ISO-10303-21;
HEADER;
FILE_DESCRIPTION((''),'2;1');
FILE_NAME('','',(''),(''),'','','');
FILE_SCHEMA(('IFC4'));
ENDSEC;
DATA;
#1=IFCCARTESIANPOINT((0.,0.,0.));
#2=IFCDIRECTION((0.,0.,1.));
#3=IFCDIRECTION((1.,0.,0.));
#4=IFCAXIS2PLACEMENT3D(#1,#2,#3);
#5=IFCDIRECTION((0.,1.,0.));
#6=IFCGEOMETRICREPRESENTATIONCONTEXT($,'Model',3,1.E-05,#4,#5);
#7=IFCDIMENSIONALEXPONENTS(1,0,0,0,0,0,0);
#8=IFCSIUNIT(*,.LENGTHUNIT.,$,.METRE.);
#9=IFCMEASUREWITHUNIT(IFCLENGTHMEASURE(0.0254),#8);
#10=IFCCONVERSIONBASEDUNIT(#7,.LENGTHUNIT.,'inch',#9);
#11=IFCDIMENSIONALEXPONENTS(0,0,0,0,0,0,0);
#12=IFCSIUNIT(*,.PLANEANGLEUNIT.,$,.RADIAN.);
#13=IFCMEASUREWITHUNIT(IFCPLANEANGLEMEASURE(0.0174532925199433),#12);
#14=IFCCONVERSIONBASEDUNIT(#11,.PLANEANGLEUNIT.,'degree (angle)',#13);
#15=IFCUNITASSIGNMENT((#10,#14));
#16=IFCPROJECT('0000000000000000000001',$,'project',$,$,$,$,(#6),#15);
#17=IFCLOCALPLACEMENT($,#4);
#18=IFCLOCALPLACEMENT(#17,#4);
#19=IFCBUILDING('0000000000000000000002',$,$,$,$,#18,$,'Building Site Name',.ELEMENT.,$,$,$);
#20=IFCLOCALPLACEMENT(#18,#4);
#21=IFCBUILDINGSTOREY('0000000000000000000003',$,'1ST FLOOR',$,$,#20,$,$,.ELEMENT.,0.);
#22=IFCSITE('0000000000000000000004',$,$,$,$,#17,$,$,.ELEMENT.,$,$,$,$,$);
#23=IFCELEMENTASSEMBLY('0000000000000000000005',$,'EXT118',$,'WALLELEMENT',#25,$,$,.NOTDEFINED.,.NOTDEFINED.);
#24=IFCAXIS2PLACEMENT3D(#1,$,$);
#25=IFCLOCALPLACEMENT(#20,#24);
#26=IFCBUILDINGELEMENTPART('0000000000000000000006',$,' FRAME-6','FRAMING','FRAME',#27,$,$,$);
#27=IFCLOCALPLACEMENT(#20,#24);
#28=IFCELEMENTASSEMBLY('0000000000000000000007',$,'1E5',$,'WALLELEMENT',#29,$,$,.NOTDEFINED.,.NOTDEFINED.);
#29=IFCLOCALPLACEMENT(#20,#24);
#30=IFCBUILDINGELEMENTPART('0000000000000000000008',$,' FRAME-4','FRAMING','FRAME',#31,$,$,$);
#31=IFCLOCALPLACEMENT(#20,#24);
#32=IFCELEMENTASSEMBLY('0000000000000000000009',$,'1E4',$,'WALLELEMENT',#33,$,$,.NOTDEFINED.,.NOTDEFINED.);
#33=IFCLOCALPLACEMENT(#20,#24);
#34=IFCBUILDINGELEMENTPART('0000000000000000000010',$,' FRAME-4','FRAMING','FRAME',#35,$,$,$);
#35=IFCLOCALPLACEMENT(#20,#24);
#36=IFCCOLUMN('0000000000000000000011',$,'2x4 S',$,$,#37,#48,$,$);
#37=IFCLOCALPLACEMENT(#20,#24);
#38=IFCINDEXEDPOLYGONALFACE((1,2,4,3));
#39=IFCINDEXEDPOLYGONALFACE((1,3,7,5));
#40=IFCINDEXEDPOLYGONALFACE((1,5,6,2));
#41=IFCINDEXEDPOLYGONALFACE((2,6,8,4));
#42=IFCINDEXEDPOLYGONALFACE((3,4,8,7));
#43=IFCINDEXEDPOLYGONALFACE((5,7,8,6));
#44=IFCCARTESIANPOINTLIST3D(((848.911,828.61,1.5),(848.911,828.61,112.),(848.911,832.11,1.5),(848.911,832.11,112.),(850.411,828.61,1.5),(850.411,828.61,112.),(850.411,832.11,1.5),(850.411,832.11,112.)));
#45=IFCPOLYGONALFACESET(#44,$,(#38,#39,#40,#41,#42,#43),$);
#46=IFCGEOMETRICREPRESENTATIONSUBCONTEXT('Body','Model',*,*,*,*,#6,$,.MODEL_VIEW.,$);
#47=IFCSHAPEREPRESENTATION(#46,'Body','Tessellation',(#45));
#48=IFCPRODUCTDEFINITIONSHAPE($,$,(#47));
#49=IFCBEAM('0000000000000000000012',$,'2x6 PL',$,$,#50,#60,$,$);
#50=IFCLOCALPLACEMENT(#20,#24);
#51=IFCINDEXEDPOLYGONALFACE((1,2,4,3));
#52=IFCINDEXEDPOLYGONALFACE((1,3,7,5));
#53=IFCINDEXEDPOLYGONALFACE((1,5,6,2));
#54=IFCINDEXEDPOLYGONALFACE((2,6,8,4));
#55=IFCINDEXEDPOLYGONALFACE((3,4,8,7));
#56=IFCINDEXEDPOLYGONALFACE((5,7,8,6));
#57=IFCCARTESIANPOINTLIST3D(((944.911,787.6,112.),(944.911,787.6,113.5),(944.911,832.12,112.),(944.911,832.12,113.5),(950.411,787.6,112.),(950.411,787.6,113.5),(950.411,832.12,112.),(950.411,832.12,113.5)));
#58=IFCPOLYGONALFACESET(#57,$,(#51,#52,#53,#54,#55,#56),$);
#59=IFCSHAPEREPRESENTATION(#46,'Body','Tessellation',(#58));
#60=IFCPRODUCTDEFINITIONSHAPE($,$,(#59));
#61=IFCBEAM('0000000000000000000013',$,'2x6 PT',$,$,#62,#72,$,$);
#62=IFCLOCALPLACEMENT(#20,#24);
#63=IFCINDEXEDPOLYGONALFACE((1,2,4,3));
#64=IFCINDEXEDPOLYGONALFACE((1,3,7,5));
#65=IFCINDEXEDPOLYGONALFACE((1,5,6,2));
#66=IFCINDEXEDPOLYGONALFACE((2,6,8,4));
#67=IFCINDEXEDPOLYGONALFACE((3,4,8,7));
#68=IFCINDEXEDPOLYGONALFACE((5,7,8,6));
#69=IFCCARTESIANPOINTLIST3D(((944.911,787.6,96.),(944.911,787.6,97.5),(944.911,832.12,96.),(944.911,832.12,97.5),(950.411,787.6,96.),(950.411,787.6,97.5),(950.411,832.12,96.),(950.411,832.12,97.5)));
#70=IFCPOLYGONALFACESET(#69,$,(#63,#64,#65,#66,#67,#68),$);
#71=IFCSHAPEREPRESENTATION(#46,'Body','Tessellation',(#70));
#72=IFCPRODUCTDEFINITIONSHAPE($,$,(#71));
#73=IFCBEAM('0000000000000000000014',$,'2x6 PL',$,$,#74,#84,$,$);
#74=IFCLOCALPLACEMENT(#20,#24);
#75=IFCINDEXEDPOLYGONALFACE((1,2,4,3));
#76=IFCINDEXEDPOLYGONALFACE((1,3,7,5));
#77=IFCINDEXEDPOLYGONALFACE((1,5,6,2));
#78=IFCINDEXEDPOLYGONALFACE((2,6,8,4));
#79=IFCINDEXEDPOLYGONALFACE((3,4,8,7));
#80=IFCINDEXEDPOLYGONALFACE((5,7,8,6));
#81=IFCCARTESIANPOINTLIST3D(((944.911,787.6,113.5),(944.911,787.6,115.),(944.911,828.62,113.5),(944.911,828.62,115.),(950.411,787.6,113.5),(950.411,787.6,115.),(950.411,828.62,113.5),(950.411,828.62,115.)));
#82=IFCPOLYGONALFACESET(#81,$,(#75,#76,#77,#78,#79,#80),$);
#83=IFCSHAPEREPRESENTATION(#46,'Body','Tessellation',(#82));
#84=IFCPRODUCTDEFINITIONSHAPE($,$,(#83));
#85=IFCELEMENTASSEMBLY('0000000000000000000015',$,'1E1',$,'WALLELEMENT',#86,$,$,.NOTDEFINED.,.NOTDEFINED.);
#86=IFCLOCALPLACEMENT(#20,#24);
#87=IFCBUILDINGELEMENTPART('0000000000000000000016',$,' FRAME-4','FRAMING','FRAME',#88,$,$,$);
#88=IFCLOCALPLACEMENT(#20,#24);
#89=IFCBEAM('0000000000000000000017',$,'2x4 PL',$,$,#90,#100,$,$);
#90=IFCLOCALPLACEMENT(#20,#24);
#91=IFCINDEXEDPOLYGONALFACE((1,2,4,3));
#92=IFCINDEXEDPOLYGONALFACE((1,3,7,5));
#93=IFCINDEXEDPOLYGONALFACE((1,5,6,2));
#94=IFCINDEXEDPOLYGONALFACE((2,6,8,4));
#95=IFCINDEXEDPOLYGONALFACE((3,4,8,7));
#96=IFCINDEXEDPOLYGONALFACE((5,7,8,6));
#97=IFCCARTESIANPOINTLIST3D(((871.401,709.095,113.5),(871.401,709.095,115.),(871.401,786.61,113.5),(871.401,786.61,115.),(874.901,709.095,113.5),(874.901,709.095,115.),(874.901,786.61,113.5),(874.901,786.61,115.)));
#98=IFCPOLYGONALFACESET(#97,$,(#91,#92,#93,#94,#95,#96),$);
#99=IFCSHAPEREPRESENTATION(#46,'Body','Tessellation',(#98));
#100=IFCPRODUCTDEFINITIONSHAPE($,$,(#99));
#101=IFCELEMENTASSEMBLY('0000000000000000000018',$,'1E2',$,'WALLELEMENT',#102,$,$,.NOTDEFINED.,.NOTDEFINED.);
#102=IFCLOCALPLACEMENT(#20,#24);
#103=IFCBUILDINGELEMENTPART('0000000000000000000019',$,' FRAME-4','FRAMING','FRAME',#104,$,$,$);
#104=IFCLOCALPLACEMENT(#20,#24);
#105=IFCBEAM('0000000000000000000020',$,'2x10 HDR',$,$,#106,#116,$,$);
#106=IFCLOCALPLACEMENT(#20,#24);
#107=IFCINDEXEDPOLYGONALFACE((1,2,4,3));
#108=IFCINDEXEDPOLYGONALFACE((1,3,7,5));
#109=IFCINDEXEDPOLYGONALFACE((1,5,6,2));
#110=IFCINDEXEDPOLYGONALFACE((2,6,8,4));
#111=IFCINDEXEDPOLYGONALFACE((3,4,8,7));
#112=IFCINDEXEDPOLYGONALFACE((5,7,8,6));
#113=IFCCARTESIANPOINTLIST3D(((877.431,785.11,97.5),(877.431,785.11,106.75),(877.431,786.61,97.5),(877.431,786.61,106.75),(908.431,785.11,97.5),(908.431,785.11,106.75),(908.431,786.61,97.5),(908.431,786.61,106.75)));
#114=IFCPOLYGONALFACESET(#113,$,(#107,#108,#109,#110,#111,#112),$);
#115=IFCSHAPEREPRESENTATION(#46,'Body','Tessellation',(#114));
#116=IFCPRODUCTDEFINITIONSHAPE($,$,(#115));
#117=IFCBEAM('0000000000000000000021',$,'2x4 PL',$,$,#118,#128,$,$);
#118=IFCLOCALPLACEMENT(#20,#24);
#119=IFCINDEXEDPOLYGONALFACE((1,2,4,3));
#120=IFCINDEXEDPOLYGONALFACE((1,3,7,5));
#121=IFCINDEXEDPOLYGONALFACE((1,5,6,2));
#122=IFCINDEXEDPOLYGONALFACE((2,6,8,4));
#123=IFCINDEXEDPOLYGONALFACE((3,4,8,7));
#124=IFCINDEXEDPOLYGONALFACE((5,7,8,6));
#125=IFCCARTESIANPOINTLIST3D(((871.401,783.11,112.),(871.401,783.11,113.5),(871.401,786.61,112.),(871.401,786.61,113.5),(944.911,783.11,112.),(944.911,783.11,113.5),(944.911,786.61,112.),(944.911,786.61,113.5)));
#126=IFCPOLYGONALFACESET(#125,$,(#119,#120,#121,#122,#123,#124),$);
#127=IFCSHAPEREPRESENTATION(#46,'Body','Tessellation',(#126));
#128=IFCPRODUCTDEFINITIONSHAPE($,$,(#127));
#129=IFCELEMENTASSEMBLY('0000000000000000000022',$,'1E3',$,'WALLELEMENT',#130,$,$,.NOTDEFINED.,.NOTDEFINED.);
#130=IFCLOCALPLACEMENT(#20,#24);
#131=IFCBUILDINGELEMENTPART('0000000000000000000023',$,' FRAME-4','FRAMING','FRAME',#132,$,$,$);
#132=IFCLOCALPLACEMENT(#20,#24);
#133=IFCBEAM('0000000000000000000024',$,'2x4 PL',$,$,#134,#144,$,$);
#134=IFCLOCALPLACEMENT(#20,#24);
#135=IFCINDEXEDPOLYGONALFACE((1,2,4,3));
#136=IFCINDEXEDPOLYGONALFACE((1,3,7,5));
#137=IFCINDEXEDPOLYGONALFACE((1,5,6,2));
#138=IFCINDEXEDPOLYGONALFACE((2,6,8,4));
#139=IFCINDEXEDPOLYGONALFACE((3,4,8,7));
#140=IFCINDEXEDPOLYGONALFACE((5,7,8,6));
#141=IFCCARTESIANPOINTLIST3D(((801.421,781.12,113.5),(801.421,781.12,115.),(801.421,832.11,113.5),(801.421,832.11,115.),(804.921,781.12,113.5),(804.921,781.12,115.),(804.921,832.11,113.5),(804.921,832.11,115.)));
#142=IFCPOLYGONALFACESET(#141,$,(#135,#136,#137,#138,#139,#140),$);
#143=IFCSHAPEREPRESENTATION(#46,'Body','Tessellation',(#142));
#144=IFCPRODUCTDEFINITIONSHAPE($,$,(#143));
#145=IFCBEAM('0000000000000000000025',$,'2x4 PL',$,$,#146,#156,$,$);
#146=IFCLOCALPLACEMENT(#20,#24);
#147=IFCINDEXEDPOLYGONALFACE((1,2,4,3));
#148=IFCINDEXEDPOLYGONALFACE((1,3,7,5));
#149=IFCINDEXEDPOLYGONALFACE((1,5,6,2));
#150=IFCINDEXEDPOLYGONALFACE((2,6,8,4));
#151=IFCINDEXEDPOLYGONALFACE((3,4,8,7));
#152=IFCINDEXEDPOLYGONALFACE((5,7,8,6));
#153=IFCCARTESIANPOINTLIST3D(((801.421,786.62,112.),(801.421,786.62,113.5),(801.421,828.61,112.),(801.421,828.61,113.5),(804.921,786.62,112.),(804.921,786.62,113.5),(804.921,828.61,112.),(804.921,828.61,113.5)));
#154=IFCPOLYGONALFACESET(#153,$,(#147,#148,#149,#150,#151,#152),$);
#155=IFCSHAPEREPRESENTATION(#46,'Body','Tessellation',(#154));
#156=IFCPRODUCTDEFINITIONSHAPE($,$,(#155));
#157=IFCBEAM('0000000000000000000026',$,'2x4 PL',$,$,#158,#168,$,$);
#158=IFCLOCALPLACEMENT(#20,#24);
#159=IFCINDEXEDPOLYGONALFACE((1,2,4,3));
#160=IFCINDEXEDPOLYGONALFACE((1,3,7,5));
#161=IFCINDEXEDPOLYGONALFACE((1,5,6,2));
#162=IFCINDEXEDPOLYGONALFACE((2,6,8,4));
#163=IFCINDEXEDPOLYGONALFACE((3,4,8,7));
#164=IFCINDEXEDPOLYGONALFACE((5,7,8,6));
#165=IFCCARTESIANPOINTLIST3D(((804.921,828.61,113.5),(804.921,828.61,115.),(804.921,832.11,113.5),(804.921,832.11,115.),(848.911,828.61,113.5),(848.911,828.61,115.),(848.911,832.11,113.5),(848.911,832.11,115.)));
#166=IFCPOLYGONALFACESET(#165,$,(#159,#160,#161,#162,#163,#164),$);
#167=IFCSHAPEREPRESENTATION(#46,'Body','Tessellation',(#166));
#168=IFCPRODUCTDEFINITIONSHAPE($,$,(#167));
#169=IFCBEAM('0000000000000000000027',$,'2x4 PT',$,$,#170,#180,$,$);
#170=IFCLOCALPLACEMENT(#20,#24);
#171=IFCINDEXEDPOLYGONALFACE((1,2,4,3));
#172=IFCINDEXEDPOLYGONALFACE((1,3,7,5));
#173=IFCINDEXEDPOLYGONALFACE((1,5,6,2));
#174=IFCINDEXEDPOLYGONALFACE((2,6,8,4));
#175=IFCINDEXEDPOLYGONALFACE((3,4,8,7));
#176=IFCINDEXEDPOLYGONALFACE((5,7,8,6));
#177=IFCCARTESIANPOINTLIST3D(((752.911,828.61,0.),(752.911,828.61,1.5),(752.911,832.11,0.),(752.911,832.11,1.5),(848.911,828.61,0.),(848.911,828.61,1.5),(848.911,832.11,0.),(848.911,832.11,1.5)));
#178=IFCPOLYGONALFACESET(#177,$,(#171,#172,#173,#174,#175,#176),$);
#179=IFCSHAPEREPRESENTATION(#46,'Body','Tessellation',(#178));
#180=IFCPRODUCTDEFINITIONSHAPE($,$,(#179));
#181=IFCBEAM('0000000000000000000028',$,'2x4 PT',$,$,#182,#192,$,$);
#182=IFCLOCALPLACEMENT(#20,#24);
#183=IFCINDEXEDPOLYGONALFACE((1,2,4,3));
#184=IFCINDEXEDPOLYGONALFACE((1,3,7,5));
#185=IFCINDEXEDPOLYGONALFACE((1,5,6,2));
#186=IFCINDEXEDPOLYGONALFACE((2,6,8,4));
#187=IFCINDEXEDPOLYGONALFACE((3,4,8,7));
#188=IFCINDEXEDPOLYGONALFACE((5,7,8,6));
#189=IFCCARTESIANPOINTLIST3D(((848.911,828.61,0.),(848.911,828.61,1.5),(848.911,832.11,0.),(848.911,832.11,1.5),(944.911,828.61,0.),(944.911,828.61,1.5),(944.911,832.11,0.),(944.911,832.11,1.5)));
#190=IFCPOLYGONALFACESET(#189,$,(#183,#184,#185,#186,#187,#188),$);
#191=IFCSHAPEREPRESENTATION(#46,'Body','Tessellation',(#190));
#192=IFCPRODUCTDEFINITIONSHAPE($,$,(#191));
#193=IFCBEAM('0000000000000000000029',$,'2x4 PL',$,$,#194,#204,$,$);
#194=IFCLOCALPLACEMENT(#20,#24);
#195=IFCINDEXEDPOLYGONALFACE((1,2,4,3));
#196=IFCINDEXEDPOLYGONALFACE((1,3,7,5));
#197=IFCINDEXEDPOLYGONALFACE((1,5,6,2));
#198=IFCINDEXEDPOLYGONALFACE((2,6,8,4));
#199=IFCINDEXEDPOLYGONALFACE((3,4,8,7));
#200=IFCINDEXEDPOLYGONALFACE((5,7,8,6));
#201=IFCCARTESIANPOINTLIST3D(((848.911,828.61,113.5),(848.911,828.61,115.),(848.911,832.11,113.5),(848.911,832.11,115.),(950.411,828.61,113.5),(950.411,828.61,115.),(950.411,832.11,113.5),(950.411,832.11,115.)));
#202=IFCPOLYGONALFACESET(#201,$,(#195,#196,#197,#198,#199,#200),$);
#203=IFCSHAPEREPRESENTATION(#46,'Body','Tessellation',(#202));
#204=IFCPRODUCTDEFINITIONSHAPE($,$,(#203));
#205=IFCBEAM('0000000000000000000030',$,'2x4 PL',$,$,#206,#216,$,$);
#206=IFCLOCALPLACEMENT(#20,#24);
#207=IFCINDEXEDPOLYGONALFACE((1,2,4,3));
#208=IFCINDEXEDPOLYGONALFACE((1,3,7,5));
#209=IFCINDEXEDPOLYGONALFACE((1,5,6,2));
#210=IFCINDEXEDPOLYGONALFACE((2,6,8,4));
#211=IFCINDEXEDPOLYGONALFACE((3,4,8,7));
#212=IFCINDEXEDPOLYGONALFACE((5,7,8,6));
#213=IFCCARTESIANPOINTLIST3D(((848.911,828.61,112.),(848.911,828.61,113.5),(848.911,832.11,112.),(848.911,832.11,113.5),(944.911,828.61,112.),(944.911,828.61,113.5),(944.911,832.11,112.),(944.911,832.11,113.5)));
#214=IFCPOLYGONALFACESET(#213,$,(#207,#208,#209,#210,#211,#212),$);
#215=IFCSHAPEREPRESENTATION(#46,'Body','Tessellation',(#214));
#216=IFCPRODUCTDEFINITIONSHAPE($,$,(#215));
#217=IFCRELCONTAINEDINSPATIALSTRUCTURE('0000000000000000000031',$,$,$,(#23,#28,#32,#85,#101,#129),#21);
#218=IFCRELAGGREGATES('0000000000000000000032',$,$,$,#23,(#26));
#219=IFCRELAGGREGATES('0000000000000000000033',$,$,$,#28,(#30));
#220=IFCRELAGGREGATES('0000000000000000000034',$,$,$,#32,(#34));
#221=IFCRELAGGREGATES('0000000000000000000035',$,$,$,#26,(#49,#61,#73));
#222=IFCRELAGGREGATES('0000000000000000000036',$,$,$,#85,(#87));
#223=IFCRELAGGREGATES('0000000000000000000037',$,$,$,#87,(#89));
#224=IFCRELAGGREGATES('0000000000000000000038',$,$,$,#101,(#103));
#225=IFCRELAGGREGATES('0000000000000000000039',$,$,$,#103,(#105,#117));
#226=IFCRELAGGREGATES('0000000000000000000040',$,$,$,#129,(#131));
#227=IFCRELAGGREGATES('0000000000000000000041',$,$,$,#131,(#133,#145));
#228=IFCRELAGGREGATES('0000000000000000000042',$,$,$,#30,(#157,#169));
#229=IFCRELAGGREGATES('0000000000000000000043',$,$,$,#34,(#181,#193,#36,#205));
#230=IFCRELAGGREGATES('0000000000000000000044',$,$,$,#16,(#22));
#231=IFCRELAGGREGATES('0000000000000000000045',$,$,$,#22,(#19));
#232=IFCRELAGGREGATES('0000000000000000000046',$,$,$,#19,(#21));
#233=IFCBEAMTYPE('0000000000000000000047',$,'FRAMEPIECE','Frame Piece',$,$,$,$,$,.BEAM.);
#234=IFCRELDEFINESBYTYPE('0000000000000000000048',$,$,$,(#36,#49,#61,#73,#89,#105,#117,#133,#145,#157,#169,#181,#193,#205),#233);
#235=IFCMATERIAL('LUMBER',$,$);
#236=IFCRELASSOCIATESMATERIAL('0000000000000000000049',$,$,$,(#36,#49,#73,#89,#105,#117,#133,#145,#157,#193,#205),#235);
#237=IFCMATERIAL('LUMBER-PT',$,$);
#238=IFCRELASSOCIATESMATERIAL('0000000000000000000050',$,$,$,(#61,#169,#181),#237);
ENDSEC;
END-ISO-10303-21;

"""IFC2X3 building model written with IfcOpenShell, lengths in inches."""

from ifc_helpers import new_model, entity, si_unit, converted_unit, direction, frame, frame_2d, origin_with_axes, place, context, subcontext, project, spatial, rectangle, extrude, material, type_object, element, aggregate, save


model = new_model("IFC2X3")

# Units and contexts
model_context = context("Model", 3, precision=1e-05, world=origin_with_axes(), true_north=direction((0.0, 1.0, 0.0)))
body_context = subcontext(model_context, "Body", "Model", "MODEL_VIEW")
ifc_project = project(units=[converted_unit("LENGTHUNIT", "inch", entity("IfcLengthMeasure", 0.0254), si_unit("LENGTHUNIT", "METRE"), dimensions=[1, 0, 0, 0, 0, 0, 0]), converted_unit("PLANEANGLEUNIT", "degree (angle)", entity("IfcPlaneAngleMeasure", 0.0174532925199433), si_unit("PLANEANGLEUNIT", "RADIAN"), dimensions=[0, 0, 0, 0, 0, 0, 0])], contexts=[model_context])

# Site, building, storey
site_placement = place(None, origin_with_axes())
site = spatial("IfcSite", under=ifc_project, at=site_placement, CompositionType="ELEMENT")
building_placement = place(site_placement, origin_with_axes())
building = spatial("IfcBuilding", under=site, at=building_placement, LongName="Building Site Name", CompositionType="ELEMENT")
storey_placement = place(building_placement, origin_with_axes())
storey = spatial("IfcBuildingStorey", under=building, at=storey_placement, Name="1ST FLOOR", CompositionType="ELEMENT", Elevation=0.0)

# Element assemblies, building element parts, column
assembly_1_placement = place(storey_placement, origin_with_axes())
assembly_1 = element("IfcElementAssembly", 1, at=assembly_1_placement, inside=storey, Name="EXT118", ObjectType="WALLELEMENT", AssemblyPlace="NOTDEFINED", PredefinedType="NOTDEFINED")
building_element_part_1 = element("IfcBuildingElementPart", 2, Name=" FRAME-6", Description="FRAMING", ObjectType="FRAME")
aggregate(assembly_1, [building_element_part_1])
ifc_material_1 = material(Name="LUMBER")
beam_type = type_object("IfcBeamType", Name="FRAMEPIECE", Description="Frame Piece", PredefinedType="BEAM")
assembly_2_placement = place(storey_placement, origin_with_axes())
assembly_2 = element("IfcElementAssembly", 3, at=assembly_2_placement, inside=storey, Name="1E5", ObjectType="WALLELEMENT", AssemblyPlace="NOTDEFINED", PredefinedType="NOTDEFINED")
building_element_part_2 = element("IfcBuildingElementPart", 4, Name=" FRAME-4", Description="FRAMING", ObjectType="FRAME")
aggregate(assembly_2, [building_element_part_2])
assembly_3_placement = place(storey_placement, origin_with_axes())
assembly_3 = element("IfcElementAssembly", 5, at=assembly_3_placement, inside=storey, Name="1E4", ObjectType="WALLELEMENT", AssemblyPlace="NOTDEFINED", PredefinedType="NOTDEFINED")
building_element_part_3 = element("IfcBuildingElementPart", 6, Name=" FRAME-4", Description="FRAMING", ObjectType="FRAME")
aggregate(assembly_3, [building_element_part_3])
column_1_placement = place(assembly_3_placement, frame((849.661, 830.36, 1.5), z_axis=(0.0, 0.0, 1.0), x_axis=(1.0, 0.0, 0.0)))
column_1 = element("IfcColumn", 7, at=column_1_placement, type_object=beam_type, material=ifc_material_1, Name="2x4 S", context=body_context, shape_type="SweptSolid", body=[
    extrude(rectangle(XDim=1.5, YDim=3.5, at=frame_2d((0.0, 0.0), x_axis=(-1.0, 0.0))), frame((0.0, 0.0, 0.0), z_axis=(0.0, 0.0, 1.0), x_axis=(1.0, 0.0, 0.0)), (0.0, 0.0, 1.0), 110.5),
])

# Beams
beam_1_placement = place(assembly_1_placement, frame((947.661, 832.12, 112.75), z_axis=(0.0, -1.0, 0.0), x_axis=(0.0, 0.0, -1.0)))
beam_1 = element("IfcBeam", 8, at=beam_1_placement, type_object=beam_type, material=ifc_material_1, Name="2x6 PL", context=body_context, shape_type="SweptSolid", body=[
    extrude(rectangle(XDim=1.5, YDim=5.5, at=frame_2d((0.0, 0.0), x_axis=(-1.0, 0.0))), frame((0.0, 0.0, 0.0), z_axis=(0.0, 0.0, 1.0), x_axis=(1.0, 0.0, 0.0)), (0.0, 0.0, 1.0), 44.52),
])
ifc_material_2 = material(Name="LUMBER-PT")
beam_2_placement = place(assembly_1_placement, frame((947.661, 787.6, 96.75), z_axis=(0.0, 1.0, 0.0), x_axis=(0.0, 0.0, 1.0)))
beam_2 = element("IfcBeam", 9, at=beam_2_placement, type_object=beam_type, material=ifc_material_2, Name="2x6 PT", context=body_context, shape_type="SweptSolid", body=[
    extrude(rectangle(XDim=1.5, YDim=5.5, at=frame_2d((0.0, 0.0), x_axis=(-1.0, 0.0))), origin_with_axes(), (0.0, 0.0, 1.0), 44.52),
])
beam_3_placement = place(assembly_1_placement, frame((947.661, 828.62, 114.25), z_axis=(0.0, -1.0, 0.0), x_axis=(0.0, 0.0, -1.0)))
beam_3 = element("IfcBeam", 10, at=beam_3_placement, type_object=beam_type, material=ifc_material_1, Name="2x6 PL", context=body_context, shape_type="SweptSolid", body=[
    extrude(rectangle(XDim=1.5, YDim=5.5, at=frame_2d((0.0, 0.0), x_axis=(-1.0, 0.0))), origin_with_axes(), (0.0, 0.0, 1.0), 41.02),
])
aggregate(building_element_part_1, [beam_1, beam_2, beam_3])

# Element assembly, building element part, beam
assembly_4_placement = place(storey_placement, origin_with_axes())
assembly_4 = element("IfcElementAssembly", 11, at=assembly_4_placement, inside=storey, Name="1E1", ObjectType="WALLELEMENT", AssemblyPlace="NOTDEFINED", PredefinedType="NOTDEFINED")
building_element_part_4 = element("IfcBuildingElementPart", 12, Name=" FRAME-4", Description="FRAMING", ObjectType="FRAME")
aggregate(assembly_4, [building_element_part_4])
beam_4_placement = place(assembly_4_placement, frame((873.151, 786.61, 114.25), z_axis=(0.0, -1.0, 0.0), x_axis=(0.0, 0.0, -1.0)))
beam_4 = element("IfcBeam", 13, at=beam_4_placement, type_object=beam_type, material=ifc_material_1, Name="2x4 PL", context=body_context, shape_type="SweptSolid", body=[
    extrude(rectangle(XDim=1.5, YDim=3.5, at=frame_2d((0.0, 0.0), x_axis=(-1.0, 0.0))), origin_with_axes(), (0.0, 0.0, 1.0), 77.515),
])
aggregate(building_element_part_4, [beam_4])

# Element assemblies, building element parts, beams
assembly_5_placement = place(storey_placement, origin_with_axes())
assembly_5 = element("IfcElementAssembly", 14, at=assembly_5_placement, inside=storey, Name="1E2", ObjectType="WALLELEMENT", AssemblyPlace="NOTDEFINED", PredefinedType="NOTDEFINED")
building_element_part_5 = element("IfcBuildingElementPart", 15, Name=" FRAME-4", Description="FRAMING", ObjectType="FRAME")
aggregate(assembly_5, [building_element_part_5])
beam_5_placement = place(assembly_5_placement, frame((877.431, 785.86, 102.125), z_axis=(1.0, 0.0, 0.0), x_axis=(0.0, 1.0, 0.0)))
beam_5 = element("IfcBeam", 16, at=beam_5_placement, type_object=beam_type, material=ifc_material_1, Name="2x10 HDR", context=body_context, shape_type="SweptSolid", body=[
    extrude(rectangle(XDim=1.5, YDim=9.25, at=frame_2d((0.0, 0.0), x_axis=(-1.0, 0.0))), origin_with_axes(), (0.0, 0.0, 1.0), 31.0),
])
beam_6_placement = place(assembly_5_placement, frame((944.911, 784.86, 112.75), z_axis=(-1.0, 0.0, 0.0), x_axis=(0.0, 0.0, -1.0)))
beam_6 = element("IfcBeam", 17, at=beam_6_placement, type_object=beam_type, material=ifc_material_1, Name="2x4 PL", context=body_context, shape_type="SweptSolid", body=[
    extrude(rectangle(XDim=1.5, YDim=3.5, at=frame_2d((0.0, 0.0), x_axis=(-1.0, 0.0))), frame((0.0, 0.0, 0.0), z_axis=(0.0, 0.0, 1.0), x_axis=(1.0, 0.0, 0.0)), (0.0, 0.0, 1.0), 73.51),
])
aggregate(building_element_part_5, [beam_5, beam_6])
assembly_6_placement = place(storey_placement, origin_with_axes())
assembly_6 = element("IfcElementAssembly", 18, at=assembly_6_placement, inside=storey, Name="1E3", ObjectType="WALLELEMENT", AssemblyPlace="NOTDEFINED", PredefinedType="NOTDEFINED")
building_element_part_6 = element("IfcBuildingElementPart", 19, Name=" FRAME-4", Description="FRAMING", ObjectType="FRAME")
aggregate(assembly_6, [building_element_part_6])
beam_7_placement = place(assembly_6_placement, frame((803.171, 832.11, 114.25), z_axis=(0.0, -1.0, 0.0), x_axis=(0.0, 0.0, -1.0)))
beam_7 = element("IfcBeam", 20, at=beam_7_placement, type_object=beam_type, material=ifc_material_1, Name="2x4 PL", context=body_context, shape_type="SweptSolid", body=[
    extrude(rectangle(XDim=1.5, YDim=3.5, at=frame_2d((0.0, 0.0), x_axis=(-1.0, 0.0))), origin_with_axes(), (0.0, 0.0, 1.0), 50.99),
])
beam_8_placement = place(assembly_6_placement, frame((803.171, 828.61, 112.75), z_axis=(0.0, -1.0, 0.0), x_axis=(0.0, 0.0, -1.0)))
beam_8 = element("IfcBeam", 21, at=beam_8_placement, type_object=beam_type, material=ifc_material_1, Name="2x4 PL", context=body_context, shape_type="SweptSolid", body=[
    extrude(rectangle(XDim=1.5, YDim=3.5, at=frame_2d((0.0, 0.0), x_axis=(-1.0, 0.0))), frame((0.0, 0.0, 0.0), z_axis=(0.0, 0.0, 1.0), x_axis=(1.0, 0.0, 0.0)), (0.0, 0.0, 1.0), 41.99),
])
aggregate(building_element_part_6, [beam_7, beam_8])

# Beams
beam_9_placement = place(assembly_2_placement, frame((804.921, 830.36, 114.25), z_axis=(1.0, 0.0, 0.0), x_axis=(0.0, 0.0, -1.0)))
beam_9 = element("IfcBeam", 22, at=beam_9_placement, type_object=beam_type, material=ifc_material_1, Name="2x4 PL", context=body_context, shape_type="SweptSolid", body=[
    extrude(rectangle(XDim=1.5, YDim=3.5, at=frame_2d((0.0, 0.0), x_axis=(-1.0, 0.0))), origin_with_axes(), (0.0, 0.0, 1.0), 43.99),
])
beam_10_placement = place(assembly_2_placement, frame((848.911, 830.36, 0.75), z_axis=(-1.0, 0.0, 0.0), x_axis=(0.0, 0.0, 1.0)))
beam_10 = element("IfcBeam", 23, at=beam_10_placement, type_object=beam_type, material=ifc_material_2, Name="2x4 PT", context=body_context, shape_type="SweptSolid", body=[
    extrude(rectangle(XDim=1.5, YDim=3.5, at=frame_2d((0.0, 0.0), x_axis=(-1.0, 0.0))), origin_with_axes(), (0.0, 0.0, 1.0), 96.0),
])
aggregate(building_element_part_2, [beam_9, beam_10])
beam_11_placement = place(assembly_3_placement, frame((944.911, 830.36, 0.75), z_axis=(-1.0, 0.0, 0.0), x_axis=(0.0, 0.0, 1.0)))
beam_11 = element("IfcBeam", 24, at=beam_11_placement, type_object=beam_type, material=ifc_material_2, Name="2x4 PT", context=body_context, shape_type="SweptSolid", body=[
    extrude(rectangle(XDim=1.5, YDim=3.5, at=frame_2d((0.0, 0.0), x_axis=(-1.0, 0.0))), origin_with_axes(), (0.0, 0.0, 1.0), 96.0),
])
beam_12_placement = place(assembly_3_placement, frame((848.911, 830.36, 114.25), z_axis=(1.0, 0.0, 0.0), x_axis=(0.0, 0.0, -1.0)))
beam_12 = element("IfcBeam", 25, at=beam_12_placement, type_object=beam_type, material=ifc_material_1, Name="2x4 PL", context=body_context, shape_type="SweptSolid", body=[
    extrude(rectangle(XDim=1.5, YDim=3.5, at=frame_2d((0.0, 0.0), x_axis=(-1.0, 0.0))), origin_with_axes(), (0.0, 0.0, 1.0), 101.5),
])
beam_13_placement = place(assembly_3_placement, frame((848.911, 830.36, 112.75), z_axis=(1.0, 0.0, 0.0), x_axis=(0.0, 0.0, -1.0)))
beam_13 = element("IfcBeam", 26, at=beam_13_placement, type_object=beam_type, material=ifc_material_1, Name="2x4 PL", context=body_context, shape_type="SweptSolid", body=[
    extrude(rectangle(XDim=1.5, YDim=3.5, at=frame_2d((0.0, 0.0), x_axis=(-1.0, 0.0))), origin_with_axes(), (0.0, 0.0, 1.0), 96.0),
])
aggregate(building_element_part_3, [beam_11, beam_12, column_1, beam_13])

save(model, "model.ifc")
